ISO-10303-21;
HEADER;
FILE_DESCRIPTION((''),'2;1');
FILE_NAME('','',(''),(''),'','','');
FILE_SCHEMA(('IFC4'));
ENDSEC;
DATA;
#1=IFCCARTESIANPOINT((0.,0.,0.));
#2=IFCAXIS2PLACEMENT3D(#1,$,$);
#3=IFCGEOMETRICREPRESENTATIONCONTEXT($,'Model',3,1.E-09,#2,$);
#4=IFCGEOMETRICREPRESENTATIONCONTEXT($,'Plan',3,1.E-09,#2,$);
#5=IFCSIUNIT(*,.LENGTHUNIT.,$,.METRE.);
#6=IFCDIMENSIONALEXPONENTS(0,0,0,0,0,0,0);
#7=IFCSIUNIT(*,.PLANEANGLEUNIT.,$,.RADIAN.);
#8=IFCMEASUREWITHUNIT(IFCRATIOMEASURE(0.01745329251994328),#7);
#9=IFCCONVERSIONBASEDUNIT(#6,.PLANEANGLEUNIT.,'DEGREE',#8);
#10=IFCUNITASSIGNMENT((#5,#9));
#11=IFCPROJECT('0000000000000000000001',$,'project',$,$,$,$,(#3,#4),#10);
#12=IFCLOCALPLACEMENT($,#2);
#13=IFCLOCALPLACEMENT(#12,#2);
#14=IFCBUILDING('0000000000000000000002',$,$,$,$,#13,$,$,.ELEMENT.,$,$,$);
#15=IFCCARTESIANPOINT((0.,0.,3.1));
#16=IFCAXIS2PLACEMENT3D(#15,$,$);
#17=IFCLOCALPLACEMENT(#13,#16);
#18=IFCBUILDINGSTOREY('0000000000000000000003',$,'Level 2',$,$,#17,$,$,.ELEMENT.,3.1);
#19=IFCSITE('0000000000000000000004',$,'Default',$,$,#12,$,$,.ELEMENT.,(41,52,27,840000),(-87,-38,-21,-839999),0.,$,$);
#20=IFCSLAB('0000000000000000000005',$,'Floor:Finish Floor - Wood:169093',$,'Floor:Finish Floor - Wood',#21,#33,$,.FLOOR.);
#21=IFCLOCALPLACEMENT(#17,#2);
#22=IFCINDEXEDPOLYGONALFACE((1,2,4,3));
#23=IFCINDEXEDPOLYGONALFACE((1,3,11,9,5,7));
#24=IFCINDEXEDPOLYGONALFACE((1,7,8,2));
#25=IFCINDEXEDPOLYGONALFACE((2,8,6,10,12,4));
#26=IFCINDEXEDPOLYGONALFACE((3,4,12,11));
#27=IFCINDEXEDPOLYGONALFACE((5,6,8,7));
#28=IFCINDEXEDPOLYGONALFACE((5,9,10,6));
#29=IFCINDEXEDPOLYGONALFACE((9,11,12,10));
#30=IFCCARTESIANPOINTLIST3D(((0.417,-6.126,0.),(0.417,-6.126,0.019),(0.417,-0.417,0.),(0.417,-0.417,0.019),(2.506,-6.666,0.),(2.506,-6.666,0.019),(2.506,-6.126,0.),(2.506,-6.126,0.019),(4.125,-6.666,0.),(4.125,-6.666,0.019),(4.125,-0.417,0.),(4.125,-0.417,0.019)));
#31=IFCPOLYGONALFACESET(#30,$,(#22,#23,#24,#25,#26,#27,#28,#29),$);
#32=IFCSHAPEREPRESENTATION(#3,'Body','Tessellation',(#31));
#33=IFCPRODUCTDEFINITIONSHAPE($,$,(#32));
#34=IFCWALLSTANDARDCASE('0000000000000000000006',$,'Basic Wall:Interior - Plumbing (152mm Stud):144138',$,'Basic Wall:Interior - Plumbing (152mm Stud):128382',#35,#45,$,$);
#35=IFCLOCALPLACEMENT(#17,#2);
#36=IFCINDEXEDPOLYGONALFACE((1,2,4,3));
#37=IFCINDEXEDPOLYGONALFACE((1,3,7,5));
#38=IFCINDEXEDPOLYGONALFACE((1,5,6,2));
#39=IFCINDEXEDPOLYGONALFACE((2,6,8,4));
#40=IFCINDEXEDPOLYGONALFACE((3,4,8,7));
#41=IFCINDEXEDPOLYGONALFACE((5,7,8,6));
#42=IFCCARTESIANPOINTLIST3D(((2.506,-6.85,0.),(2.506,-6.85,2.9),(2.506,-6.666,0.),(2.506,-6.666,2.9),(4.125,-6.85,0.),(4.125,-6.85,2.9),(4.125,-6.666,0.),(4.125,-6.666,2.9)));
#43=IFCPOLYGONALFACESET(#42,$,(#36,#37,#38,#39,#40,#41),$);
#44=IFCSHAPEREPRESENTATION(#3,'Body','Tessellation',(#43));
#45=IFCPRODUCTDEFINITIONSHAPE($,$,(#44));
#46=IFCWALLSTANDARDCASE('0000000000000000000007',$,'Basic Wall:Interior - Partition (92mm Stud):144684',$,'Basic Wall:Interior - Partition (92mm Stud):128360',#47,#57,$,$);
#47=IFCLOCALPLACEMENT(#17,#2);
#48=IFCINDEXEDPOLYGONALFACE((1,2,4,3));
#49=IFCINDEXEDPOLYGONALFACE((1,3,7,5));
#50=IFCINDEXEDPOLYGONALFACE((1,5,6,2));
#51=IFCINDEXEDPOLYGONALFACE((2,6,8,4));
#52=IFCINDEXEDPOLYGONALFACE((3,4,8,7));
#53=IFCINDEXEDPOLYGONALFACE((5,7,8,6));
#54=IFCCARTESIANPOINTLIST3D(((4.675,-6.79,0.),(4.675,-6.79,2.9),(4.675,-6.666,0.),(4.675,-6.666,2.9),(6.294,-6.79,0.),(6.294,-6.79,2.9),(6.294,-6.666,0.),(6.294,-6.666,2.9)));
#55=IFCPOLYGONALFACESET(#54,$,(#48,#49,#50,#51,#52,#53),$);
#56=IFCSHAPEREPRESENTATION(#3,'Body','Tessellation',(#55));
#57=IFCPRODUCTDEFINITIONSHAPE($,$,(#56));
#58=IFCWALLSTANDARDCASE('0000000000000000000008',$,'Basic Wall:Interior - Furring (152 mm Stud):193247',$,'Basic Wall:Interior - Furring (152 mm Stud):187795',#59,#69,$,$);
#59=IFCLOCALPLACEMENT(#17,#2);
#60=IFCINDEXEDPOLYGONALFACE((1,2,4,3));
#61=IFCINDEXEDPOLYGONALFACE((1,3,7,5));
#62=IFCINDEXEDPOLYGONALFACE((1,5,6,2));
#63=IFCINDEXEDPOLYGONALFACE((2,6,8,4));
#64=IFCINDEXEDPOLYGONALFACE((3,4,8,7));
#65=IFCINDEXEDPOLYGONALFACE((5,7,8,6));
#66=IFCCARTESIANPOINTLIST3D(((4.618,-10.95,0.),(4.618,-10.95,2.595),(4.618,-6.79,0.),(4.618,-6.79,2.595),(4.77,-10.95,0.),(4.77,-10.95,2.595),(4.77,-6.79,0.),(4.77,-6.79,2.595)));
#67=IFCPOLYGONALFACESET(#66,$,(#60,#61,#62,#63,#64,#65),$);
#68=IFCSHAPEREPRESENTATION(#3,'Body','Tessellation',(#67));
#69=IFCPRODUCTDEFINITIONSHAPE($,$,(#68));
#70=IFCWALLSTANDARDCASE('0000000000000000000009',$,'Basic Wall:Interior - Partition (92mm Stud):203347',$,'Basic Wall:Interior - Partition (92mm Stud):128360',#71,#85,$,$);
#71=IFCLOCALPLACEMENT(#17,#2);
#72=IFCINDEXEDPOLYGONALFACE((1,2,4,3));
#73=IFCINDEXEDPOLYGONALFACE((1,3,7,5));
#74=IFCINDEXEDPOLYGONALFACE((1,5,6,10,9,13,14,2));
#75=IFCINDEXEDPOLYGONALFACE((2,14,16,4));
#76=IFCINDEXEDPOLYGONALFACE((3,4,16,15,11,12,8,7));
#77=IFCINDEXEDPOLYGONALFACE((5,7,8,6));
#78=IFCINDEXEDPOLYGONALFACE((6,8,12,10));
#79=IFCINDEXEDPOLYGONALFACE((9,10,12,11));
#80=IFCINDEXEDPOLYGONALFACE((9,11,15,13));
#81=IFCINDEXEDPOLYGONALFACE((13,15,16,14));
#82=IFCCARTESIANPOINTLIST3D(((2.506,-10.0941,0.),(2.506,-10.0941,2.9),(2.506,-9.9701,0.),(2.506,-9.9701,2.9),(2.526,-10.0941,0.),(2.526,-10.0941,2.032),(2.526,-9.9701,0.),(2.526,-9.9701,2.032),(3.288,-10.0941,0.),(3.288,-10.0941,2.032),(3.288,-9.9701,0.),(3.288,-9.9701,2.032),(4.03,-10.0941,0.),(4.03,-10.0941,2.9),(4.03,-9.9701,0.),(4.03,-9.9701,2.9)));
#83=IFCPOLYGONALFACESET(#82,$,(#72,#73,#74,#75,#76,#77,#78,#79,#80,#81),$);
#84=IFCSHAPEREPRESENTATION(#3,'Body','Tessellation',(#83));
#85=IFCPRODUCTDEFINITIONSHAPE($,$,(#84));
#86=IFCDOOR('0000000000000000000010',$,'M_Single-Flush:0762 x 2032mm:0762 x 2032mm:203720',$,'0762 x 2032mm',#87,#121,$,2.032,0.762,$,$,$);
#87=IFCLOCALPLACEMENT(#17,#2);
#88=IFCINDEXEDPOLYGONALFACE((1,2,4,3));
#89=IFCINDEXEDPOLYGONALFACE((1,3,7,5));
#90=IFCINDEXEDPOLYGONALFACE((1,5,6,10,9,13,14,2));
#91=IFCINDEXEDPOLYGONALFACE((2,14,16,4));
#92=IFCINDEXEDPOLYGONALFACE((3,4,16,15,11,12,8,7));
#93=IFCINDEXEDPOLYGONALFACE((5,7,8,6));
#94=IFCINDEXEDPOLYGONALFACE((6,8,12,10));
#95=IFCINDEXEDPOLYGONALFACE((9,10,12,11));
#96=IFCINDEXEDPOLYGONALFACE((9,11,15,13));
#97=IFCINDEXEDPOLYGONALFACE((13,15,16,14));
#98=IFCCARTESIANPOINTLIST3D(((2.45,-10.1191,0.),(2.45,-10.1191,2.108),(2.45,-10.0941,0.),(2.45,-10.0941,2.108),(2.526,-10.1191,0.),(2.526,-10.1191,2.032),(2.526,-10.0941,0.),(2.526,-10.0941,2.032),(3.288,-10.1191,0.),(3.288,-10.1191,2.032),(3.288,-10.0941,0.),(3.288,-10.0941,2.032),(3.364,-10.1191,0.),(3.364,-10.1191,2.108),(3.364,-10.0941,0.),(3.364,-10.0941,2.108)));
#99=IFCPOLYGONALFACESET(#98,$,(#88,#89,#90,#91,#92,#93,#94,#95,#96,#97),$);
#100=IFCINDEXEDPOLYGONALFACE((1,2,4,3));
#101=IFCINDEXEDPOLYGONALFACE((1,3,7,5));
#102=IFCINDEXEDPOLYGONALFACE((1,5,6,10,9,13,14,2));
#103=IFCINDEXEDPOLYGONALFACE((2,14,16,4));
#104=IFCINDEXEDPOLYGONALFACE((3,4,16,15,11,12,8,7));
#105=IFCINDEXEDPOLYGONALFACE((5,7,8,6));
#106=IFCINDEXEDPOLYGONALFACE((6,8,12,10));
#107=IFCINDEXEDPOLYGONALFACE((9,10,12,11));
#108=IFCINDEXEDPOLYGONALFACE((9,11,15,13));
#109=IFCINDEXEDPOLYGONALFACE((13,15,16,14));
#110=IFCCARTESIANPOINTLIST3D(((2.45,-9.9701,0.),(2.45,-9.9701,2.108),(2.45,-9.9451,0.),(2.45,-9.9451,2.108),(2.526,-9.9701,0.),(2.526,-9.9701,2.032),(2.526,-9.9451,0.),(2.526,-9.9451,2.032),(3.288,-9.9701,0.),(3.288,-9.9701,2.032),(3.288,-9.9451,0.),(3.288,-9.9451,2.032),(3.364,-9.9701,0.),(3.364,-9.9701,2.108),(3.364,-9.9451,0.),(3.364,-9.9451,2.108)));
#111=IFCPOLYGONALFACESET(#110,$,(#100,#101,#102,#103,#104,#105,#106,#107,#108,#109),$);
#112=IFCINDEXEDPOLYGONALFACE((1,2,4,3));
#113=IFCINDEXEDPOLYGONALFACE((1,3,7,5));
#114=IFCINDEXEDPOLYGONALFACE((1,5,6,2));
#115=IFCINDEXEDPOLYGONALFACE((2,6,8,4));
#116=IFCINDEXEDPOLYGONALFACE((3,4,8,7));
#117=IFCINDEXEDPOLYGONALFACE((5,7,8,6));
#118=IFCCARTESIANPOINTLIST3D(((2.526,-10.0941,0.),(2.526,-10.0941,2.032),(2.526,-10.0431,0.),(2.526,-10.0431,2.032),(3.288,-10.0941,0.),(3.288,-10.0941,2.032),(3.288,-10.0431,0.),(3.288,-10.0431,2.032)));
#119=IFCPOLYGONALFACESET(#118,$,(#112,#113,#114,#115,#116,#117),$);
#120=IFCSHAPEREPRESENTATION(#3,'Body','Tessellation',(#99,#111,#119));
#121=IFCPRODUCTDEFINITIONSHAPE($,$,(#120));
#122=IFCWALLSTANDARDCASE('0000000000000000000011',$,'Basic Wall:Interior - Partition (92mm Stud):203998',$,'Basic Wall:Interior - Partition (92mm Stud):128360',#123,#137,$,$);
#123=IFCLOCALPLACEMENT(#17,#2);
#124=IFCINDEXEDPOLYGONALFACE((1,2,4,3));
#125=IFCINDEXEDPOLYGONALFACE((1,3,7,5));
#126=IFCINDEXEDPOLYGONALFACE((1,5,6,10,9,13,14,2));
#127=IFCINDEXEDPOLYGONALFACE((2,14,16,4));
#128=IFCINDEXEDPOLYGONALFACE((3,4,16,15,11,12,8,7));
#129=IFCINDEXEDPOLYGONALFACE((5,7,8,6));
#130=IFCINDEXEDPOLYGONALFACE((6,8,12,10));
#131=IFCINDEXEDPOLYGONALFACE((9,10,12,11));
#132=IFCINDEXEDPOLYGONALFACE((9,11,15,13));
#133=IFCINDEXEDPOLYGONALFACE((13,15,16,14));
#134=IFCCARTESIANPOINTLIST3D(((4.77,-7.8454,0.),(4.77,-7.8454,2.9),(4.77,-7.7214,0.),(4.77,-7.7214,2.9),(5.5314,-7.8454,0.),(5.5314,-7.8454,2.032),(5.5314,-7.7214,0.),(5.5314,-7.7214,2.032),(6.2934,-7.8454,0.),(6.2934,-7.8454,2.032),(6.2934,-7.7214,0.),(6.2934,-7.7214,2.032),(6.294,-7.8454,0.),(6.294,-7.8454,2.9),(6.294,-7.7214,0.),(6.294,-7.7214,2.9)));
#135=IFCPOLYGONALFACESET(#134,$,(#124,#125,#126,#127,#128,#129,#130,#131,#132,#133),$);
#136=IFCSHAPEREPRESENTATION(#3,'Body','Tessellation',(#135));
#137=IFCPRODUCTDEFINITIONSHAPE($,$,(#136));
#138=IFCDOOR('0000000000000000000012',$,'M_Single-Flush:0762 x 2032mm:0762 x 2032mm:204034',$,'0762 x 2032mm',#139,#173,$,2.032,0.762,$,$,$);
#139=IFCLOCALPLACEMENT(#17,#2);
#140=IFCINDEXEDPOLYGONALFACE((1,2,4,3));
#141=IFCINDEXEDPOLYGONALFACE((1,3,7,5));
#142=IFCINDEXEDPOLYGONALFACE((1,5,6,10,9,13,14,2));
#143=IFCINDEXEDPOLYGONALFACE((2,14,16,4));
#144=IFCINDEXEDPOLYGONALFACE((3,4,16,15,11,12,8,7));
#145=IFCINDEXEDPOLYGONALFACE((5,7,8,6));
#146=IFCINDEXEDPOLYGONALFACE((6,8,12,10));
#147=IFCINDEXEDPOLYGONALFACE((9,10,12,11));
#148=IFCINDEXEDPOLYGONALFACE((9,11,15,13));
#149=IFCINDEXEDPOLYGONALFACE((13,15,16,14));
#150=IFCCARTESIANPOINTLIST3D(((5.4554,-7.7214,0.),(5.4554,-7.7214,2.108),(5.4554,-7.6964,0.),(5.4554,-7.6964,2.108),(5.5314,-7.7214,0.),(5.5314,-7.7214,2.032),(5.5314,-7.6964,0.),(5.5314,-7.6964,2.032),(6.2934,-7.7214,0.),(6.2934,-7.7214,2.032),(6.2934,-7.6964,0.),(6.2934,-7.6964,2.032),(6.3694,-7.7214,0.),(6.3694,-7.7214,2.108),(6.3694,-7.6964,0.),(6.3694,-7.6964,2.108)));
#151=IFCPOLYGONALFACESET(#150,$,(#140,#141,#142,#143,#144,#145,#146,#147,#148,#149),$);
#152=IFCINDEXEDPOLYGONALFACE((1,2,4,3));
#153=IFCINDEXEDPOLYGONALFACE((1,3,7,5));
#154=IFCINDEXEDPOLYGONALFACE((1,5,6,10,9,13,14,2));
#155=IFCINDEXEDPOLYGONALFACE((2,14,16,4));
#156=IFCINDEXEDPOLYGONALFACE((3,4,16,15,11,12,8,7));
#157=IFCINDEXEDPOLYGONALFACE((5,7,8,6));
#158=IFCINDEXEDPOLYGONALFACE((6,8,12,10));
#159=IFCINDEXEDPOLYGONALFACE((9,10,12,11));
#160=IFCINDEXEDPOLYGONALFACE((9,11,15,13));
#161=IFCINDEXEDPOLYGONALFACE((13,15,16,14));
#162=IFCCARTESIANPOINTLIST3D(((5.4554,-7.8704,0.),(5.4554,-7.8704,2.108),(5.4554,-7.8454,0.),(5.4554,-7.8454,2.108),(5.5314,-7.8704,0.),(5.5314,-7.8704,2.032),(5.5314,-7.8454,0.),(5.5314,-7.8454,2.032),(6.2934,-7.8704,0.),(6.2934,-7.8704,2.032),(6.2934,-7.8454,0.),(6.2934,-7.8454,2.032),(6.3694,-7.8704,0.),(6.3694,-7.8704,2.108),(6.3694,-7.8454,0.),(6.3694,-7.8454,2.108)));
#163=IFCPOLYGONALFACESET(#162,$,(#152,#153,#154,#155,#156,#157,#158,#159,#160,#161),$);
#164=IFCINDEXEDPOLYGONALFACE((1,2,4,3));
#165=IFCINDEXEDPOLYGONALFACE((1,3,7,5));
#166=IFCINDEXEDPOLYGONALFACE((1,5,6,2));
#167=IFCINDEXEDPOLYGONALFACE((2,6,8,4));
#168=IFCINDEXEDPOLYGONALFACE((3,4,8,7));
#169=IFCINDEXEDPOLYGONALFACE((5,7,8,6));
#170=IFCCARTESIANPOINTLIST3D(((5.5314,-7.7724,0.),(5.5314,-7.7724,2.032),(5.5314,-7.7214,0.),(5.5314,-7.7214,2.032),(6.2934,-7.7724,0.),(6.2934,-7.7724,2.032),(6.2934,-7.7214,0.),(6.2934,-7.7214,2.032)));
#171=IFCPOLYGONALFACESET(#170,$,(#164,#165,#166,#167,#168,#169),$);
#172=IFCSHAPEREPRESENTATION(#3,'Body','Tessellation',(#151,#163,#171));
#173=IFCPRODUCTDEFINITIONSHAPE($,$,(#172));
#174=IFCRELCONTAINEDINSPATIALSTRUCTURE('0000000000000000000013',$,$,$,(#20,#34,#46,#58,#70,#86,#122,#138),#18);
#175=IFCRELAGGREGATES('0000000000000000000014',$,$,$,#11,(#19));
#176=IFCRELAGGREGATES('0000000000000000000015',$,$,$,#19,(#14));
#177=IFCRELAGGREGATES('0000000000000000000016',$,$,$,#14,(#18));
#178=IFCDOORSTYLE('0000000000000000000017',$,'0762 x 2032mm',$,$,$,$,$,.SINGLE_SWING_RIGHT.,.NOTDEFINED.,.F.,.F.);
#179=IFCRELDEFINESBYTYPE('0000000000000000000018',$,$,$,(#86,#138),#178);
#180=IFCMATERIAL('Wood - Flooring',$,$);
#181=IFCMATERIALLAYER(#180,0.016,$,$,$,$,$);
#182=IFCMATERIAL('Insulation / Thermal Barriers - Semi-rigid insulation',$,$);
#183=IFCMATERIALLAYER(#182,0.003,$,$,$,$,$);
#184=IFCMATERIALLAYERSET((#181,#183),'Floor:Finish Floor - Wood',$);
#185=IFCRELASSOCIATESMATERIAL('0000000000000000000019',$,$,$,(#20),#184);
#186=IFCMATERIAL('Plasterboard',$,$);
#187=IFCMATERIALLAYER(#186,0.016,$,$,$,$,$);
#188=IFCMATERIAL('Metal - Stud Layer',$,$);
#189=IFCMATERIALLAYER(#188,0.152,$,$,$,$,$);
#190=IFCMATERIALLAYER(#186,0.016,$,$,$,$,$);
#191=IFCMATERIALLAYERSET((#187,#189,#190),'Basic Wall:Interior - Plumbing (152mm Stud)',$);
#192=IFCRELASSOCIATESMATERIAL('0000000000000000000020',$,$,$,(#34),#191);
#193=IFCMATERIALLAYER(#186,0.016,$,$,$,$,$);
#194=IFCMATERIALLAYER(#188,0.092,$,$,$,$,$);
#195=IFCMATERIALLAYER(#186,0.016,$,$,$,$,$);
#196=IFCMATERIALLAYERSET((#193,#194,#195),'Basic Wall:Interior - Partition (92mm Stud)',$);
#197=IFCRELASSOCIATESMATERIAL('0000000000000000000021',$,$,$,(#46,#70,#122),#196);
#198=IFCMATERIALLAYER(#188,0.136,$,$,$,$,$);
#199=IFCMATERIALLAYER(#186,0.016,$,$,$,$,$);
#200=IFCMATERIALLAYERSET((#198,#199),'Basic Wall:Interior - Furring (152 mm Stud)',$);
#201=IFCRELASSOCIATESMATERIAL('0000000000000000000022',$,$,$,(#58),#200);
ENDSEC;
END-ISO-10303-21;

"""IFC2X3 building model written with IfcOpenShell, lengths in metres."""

from ifc_helpers import new_model, entity, si_unit, converted_unit, frame, frame_2d, origin, origin_2d_with_axis, place, context, project, spatial, polyline, rectangle, outline, extrude, source, transform, mapped, material, layer, layer_set, layer_usage, type_object, type_shapes, element, fill, save


model = new_model("IFC2X3")

# Units and contexts
model_context = context("Model", 3, precision=1e-09, world=origin())
plan_context = context("Plan", 3, precision=1e-09, world=origin())
ifc_project = project(units=[si_unit("LENGTHUNIT", "METRE"), converted_unit("PLANEANGLEUNIT", "DEGREE", entity("IfcRatioMeasure", 0.01745329251994328), si_unit("PLANEANGLEUNIT", "RADIAN"), dimensions=[0, 0, 0, 0, 0, 0, 0])], contexts=[model_context, plan_context])

# Site, building, storey
site_placement = place(None, origin())
site = spatial("IfcSite", under=ifc_project, at=site_placement, Name="Default", CompositionType="ELEMENT", RefLatitude=(41, 52, 27, 840000), RefLongitude=(-87, -38, -21, -839999), RefElevation=0.0)
building_placement = place(site_placement, origin())
building = spatial("IfcBuilding", under=site, at=building_placement, CompositionType="ELEMENT")
storey_placement = place(building_placement, frame((0.0, 0.0, 3.1)))
storey = spatial("IfcBuildingStorey", under=building, at=storey_placement, Name="Level 2", CompositionType="ELEMENT", Elevation=3.1)

# Slab
ifc_material_1 = material(Name="Wood - Flooring")
ifc_layer_1 = layer(ifc_material_1, 0.016)
ifc_material_2 = material(Name="Insulation / Thermal Barriers - Semi-rigid insulation")
ifc_layer_2 = layer(ifc_material_2, 0.003)
ifc_layer_set_1 = layer_set([ifc_layer_1, ifc_layer_2], Name="Floor:Finish Floor - Wood")
ifc_layer_usage_1 = layer_usage(ifc_layer_set_1, "AXIS3", "POSITIVE", 0.0)
slab_placement = place(storey_placement, frame((0.417, -6.666, 0.0)))
element("IfcSlab", 1, at=slab_placement, inside=storey, material=ifc_layer_usage_1, Name="Floor:Finish Floor - Wood:169093", ObjectType="Floor:Finish Floor - Wood", PredefinedType="FLOOR", context=model_context, shape_type="SweptSolid", body=[
    extrude(outline(polyline([(1.854, 3.1245), (-1.854, 3.1245), (-1.854, -3.1245), (-0.235, -3.1245), (-0.235, -2.5845), (1.854, -2.5845), (1.854, 3.1245)])), frame((1.854, 3.1245, 0.019), z_axis=(0.0, 0.0, -1.0), x_axis=(-1.0, 0.0, 0.0)), (0.0, 0.0, 1.0), 0.019),
])

# Walls
ifc_material_3 = material(Name="Plasterboard")
ifc_layer_3 = layer(ifc_material_3, 0.016)
ifc_material_4 = material(Name="Metal - Stud Layer")
ifc_layer_4 = layer(ifc_material_4, 0.152)
ifc_layer_5 = layer(ifc_material_3, 0.016)
ifc_layer_set_2 = layer_set([ifc_layer_3, ifc_layer_4, ifc_layer_5], Name="Basic Wall:Interior - Plumbing (152mm Stud)")
ifc_layer_usage_2 = layer_usage(ifc_layer_set_2, "AXIS2", "NEGATIVE", 0.092)
wall_1_placement = place(storey_placement, frame((2.506, -6.758, 0.0)))
element("IfcWallStandardCase", 2, at=wall_1_placement, inside=storey, material=ifc_layer_usage_2, Name="Basic Wall:Interior - Plumbing (152mm Stud):144138", ObjectType="Basic Wall:Interior - Plumbing (152mm Stud):128382", context=model_context, shape_type="SweptSolid", body=[
    extrude(rectangle(XDim=1.619, YDim=0.184, at=frame_2d((0.8095, 0.0), x_axis=(-1.0, 0.0))), origin(), (0.0, 0.0, 1.0), 2.9),
])
ifc_layer_6 = layer(ifc_material_3, 0.016)
ifc_layer_7 = layer(ifc_material_4, 0.092)
ifc_layer_8 = layer(ifc_material_3, 0.016)
ifc_layer_set_3 = layer_set([ifc_layer_6, ifc_layer_7, ifc_layer_8], Name="Basic Wall:Interior - Partition (92mm Stud)")
ifc_layer_usage_3 = layer_usage(ifc_layer_set_3, "AXIS2", "NEGATIVE", 0.062)
wall_2_placement = place(storey_placement, frame((4.675, -6.728, 0.0)))
element("IfcWallStandardCase", 3, at=wall_2_placement, inside=storey, material=ifc_layer_usage_3, Name="Basic Wall:Interior - Partition (92mm Stud):144684", ObjectType="Basic Wall:Interior - Partition (92mm Stud):128360", context=model_context, shape_type="SweptSolid", body=[
    extrude(rectangle(XDim=1.619, YDim=0.124, at=frame_2d((0.8095, 0.0), x_axis=(-1.0, 0.0))), origin(), (0.0, 0.0, 1.0), 2.9),
])
ifc_layer_9 = layer(ifc_material_4, 0.136)
ifc_layer_10 = layer(ifc_material_3, 0.016)
ifc_layer_set_4 = layer_set([ifc_layer_9, ifc_layer_10], Name="Basic Wall:Interior - Furring (152 mm Stud)")
ifc_layer_usage_4 = layer_usage(ifc_layer_set_4, "AXIS2", "POSITIVE", -0.076)
wall_3_placement = place(storey_placement, frame((4.694, -6.79, 0.0), z_axis=(0.0, 0.0, 1.0), x_axis=(0.0, -1.0, 0.0)))
element("IfcWallStandardCase", 4, at=wall_3_placement, inside=storey, material=ifc_layer_usage_4, Name="Basic Wall:Interior - Furring (152 mm Stud):193247", ObjectType="Basic Wall:Interior - Furring (152 mm Stud):187795", context=model_context, shape_type="SweptSolid", body=[
    extrude(rectangle(XDim=4.16, YDim=0.152, at=frame_2d((2.08, 0.0), x_axis=(-1.0, 0.0))), origin(), (0.0, 0.0, 1.0), 2.595),
])

# Walls, openings, doors
ifc_layer_usage_5 = layer_usage(ifc_layer_set_3, "AXIS2", "NEGATIVE", 0.062)
wall_4_placement = place(storey_placement, frame((4.03, -10.0321, 0.0), z_axis=(0.0, 0.0, 1.0), x_axis=(-1.0, 0.0, 0.0)))
wall_4 = element("IfcWallStandardCase", 5, at=wall_4_placement, inside=storey, material=ifc_layer_usage_5, Name="Basic Wall:Interior - Partition (92mm Stud):203347", ObjectType="Basic Wall:Interior - Partition (92mm Stud):128360", context=model_context, shape_type="SweptSolid", body=[
    extrude(rectangle(XDim=1.524, YDim=0.124, at=frame_2d((0.762, 0.0), x_axis=(-1.0, 0.0))), origin(), (0.0, 0.0, 1.0), 2.9),
])
opening_1_placement = place(wall_4_placement, frame((0.742, -0.062, 0.0)))
opening_1 = element("IfcOpeningElement", 6, at=opening_1_placement, cuts=wall_4, ObjectType="Opening", context=model_context, shape_type="SweptSolid", body=[
    extrude(rectangle(XDim=0.762, YDim=2.032, at=frame_2d((1.016, 0.381), x_axis=(0.0, 1.0))), frame((0.0, 0.0, 0.0), z_axis=(0.0, 1.0, 0.0), x_axis=(0.0, 0.0, 1.0)), (0.0, 0.0, 1.0), 0.124),
])
door_style = type_object("IfcDoorStyle", Name="0762 x 2032mm", ConstructionType="NOTDEFINED", OperationType="SINGLE_SWING_RIGHT", ParameterTakesPrecedence=False, Sizeable=False)
shared_shape = source(origin(), model_context, "Body", "SweptSolid", [
    extrude(outline(polyline([(-0.457, -1.073), (0.457, -1.073), (0.457, 1.035), (0.381, 1.035), (0.381, -0.997), (-0.381, -0.997), (-0.381, 1.035), (-0.457, 1.035), (-0.457, -1.073)])), frame((0.381, 0.124, 1.035), z_axis=(0.0, 1.0, 0.0), x_axis=(1.0, 0.0, 0.0)), (0.0, 0.0, 1.0), 0.025),
    extrude(outline(polyline([(-1.073, -0.457), (1.035, -0.457), (1.035, -0.381), (-0.997, -0.381), (-0.997, 0.381), (1.035, 0.381), (1.035, 0.457), (-1.073, 0.457), (-1.073, -0.457)])), frame((0.381, -0.025, 1.035), z_axis=(0.0, 1.0, 0.0), x_axis=(0.0, 0.0, -1.0)), (0.0, 0.0, 1.0), 0.025),
    extrude(rectangle(XDim=0.051, YDim=0.762, at=origin_2d_with_axis()), frame((0.381, 0.0985, 0.0), z_axis=(0.0, 0.0, 1.0), x_axis=(0.0, 1.0, 0.0)), (0.0, 0.0, 1.0), 2.032),
])
type_shapes(door_style, [shared_shape])
door_1_placement = place(opening_1_placement, origin())
door_1 = element("IfcDoor", 7, at=door_1_placement, inside=storey, type_object=door_style, Name="M_Single-Flush:0762 x 2032mm:0762 x 2032mm:203720", ObjectType="0762 x 2032mm", OverallHeight=2.032, OverallWidth=0.762, context=model_context, shape_type="MappedRepresentation", body=[
    mapped(shared_shape, transform((0.0, 0.0, 0.0), scale=1.0)),
])
fill(opening_1, door_1)
ifc_layer_usage_6 = layer_usage(ifc_layer_set_3, "AXIS2", "POSITIVE", -0.062)
wall_5_placement = place(storey_placement, frame((4.77, -7.7834, 0.0)))
wall_5 = element("IfcWallStandardCase", 8, at=wall_5_placement, inside=storey, material=ifc_layer_usage_6, Name="Basic Wall:Interior - Partition (92mm Stud):203998", ObjectType="Basic Wall:Interior - Partition (92mm Stud):128360", context=model_context, shape_type="SweptSolid", body=[
    extrude(rectangle(XDim=1.524, YDim=0.124, at=frame_2d((0.762, 0.0), x_axis=(-1.0, 0.0))), origin(), (0.0, 0.0, 1.0), 2.9),
])
opening_2_placement = place(wall_5_placement, frame((0.7614, -0.062, 0.0)))
opening_2 = element("IfcOpeningElement", 9, at=opening_2_placement, cuts=wall_5, ObjectType="Opening", context=model_context, shape_type="SweptSolid", body=[
    extrude(rectangle(XDim=0.762, YDim=2.032, at=frame_2d((1.016, 0.381), x_axis=(0.0, 1.0))), frame((0.0, 0.0, 0.0), z_axis=(0.0, 1.0, 0.0), x_axis=(0.0, 0.0, 1.0)), (0.0, 0.0, 1.0), 0.124),
])
door_2_placement = place(opening_2_placement, origin())
door_2 = element("IfcDoor", 10, at=door_2_placement, inside=storey, type_object=door_style, Name="M_Single-Flush:0762 x 2032mm:0762 x 2032mm:204034", ObjectType="0762 x 2032mm", OverallHeight=2.032, OverallWidth=0.762, context=model_context, shape_type="MappedRepresentation", body=[
    mapped(shared_shape, transform((0.0, 0.0, 0.0), scale=1.0)),
])
fill(opening_2, door_2)

save(model, "model.ifc")
